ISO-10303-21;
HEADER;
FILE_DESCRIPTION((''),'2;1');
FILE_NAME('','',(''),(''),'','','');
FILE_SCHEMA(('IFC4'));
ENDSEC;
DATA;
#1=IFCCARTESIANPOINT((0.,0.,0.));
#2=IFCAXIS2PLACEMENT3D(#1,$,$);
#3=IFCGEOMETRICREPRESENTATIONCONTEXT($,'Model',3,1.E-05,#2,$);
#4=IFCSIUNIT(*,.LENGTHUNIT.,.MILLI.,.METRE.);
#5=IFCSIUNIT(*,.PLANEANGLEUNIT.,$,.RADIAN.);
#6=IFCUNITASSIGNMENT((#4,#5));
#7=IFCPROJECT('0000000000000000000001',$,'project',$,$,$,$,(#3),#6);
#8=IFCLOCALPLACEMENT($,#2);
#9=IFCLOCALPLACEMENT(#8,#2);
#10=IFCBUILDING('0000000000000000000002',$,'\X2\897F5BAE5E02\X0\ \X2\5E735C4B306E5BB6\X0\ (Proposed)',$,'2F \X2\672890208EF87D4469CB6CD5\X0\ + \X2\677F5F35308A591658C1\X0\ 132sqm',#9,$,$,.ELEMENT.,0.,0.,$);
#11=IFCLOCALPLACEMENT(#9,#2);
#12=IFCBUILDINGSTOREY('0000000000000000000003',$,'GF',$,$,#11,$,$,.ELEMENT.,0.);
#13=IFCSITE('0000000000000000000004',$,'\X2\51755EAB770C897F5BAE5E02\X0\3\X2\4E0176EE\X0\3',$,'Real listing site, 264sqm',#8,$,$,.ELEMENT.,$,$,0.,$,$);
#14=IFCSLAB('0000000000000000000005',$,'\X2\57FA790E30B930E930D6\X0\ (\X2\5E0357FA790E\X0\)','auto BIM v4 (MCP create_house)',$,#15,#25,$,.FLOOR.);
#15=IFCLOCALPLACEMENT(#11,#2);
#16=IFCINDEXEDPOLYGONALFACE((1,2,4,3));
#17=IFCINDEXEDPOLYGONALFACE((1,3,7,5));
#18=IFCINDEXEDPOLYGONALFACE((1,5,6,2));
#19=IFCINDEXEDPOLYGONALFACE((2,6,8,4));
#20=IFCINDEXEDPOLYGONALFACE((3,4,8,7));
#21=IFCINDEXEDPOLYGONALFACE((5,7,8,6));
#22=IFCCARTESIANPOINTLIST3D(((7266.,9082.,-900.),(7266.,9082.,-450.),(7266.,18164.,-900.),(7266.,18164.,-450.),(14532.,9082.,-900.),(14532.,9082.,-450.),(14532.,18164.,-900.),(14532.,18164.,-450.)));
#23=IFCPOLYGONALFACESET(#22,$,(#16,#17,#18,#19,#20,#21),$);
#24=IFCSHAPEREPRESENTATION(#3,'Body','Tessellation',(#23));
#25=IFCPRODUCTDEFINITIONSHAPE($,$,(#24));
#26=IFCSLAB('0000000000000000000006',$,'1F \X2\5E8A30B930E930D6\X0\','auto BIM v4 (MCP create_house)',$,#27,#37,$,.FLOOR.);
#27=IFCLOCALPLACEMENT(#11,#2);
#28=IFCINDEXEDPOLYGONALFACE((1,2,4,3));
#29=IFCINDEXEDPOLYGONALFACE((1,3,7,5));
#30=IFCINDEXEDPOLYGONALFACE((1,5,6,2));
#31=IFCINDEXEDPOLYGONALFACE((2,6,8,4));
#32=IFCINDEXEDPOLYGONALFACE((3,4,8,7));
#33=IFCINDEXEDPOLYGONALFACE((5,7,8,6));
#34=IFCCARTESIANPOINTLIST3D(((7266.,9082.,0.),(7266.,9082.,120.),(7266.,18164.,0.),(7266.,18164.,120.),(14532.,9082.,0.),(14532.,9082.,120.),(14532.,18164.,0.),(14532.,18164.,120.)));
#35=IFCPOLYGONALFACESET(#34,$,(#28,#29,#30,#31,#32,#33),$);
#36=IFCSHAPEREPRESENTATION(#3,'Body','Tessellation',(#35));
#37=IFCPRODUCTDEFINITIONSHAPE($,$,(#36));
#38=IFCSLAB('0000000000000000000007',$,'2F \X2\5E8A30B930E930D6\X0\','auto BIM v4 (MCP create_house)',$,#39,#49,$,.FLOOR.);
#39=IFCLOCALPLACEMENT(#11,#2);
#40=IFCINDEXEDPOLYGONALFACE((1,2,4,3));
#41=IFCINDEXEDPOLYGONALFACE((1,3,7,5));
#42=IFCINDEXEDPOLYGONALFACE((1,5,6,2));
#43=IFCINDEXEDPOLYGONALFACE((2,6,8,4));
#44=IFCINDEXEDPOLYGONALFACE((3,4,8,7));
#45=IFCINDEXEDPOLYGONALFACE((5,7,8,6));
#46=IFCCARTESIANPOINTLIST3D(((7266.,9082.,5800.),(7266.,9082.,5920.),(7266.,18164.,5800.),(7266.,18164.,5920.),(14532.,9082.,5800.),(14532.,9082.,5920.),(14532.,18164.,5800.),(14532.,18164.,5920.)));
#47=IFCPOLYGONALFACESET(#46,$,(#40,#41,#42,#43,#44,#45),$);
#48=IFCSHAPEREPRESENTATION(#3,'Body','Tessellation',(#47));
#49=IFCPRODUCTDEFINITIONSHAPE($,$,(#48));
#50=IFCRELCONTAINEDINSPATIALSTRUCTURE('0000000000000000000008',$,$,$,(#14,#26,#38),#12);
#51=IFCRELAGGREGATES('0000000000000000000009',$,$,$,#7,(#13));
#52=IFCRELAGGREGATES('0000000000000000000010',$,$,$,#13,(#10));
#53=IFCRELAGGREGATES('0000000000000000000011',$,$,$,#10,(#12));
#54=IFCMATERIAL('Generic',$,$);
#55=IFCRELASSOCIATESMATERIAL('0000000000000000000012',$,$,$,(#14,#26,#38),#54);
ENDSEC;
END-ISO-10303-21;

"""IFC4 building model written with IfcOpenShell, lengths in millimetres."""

from ifc_helpers import new_model, si_unit, frame, frame_2d, origin, place, context, project, spatial, rectangle, extrude, material, element, save


model = new_model("IFC4")

# Units and contexts
model_context = context("Model", 3, precision=1e-05, world=origin())
ifc_project = project(units=[si_unit("LENGTHUNIT", "METRE", prefix="MILLI"), si_unit("PLANEANGLEUNIT", "RADIAN")], contexts=[model_context])

# Site, building, storey
site_placement = place(None, origin())
site = spatial("IfcSite", under=ifc_project, at=site_placement, Name="兵庫県西宮市3丁目3", ObjectType="Real listing site, 264sqm", CompositionType="ELEMENT", RefElevation=0.0)
building_placement = place(site_placement, origin())
building = spatial("IfcBuilding", under=site, at=building_placement, Name="西宮市 平屋の家 (Proposed)", ObjectType="2F 木造軸組構法 + 板張り外壁 132sqm", CompositionType="ELEMENT", ElevationOfRefHeight=0.0, ElevationOfTerrain=0.0)
storey_placement = place(building_placement, origin())
storey = spatial("IfcBuildingStorey", under=building, at=storey_placement, Name="GF", CompositionType="ELEMENT", Elevation=0.0)

# Slabs
ifc_material = material(Name="Generic")
slab_1_placement = place(storey_placement, frame((3633.0, 4541.0, -450.0)))
element("IfcSlab", 1, at=slab_1_placement, inside=storey, material=ifc_material, Name="基礎スラブ (布基礎)", Description="auto BIM v4 (MCP create_house)", PredefinedType="FLOOR", context=model_context, shape_type="SweptSolid", body=[
    extrude(rectangle(XDim=7266.0, YDim=9082.0, at=frame_2d((3633.0, 4541.0))), frame((3633.0, 4541.0, -450.0)), (0.0, 0.0, 1.0), 450.0),
])
slab_2_placement = place(storey_placement, frame((3633.0, 4541.0, 0.0)))
element("IfcSlab", 2, at=slab_2_placement, inside=storey, material=ifc_material, Name="1F 床スラブ", Description="auto BIM v4 (MCP create_house)", PredefinedType="FLOOR", context=model_context, shape_type="SweptSolid", body=[
    extrude(rectangle(XDim=7266.0, YDim=9082.0, at=frame_2d((3633.0, 4541.0))), frame((3633.0, 4541.0, 0.0)), (0.0, 0.0, 1.0), 120.0),
])
slab_3_placement = place(storey_placement, frame((3633.0, 4541.0, 2900.0)))
element("IfcSlab", 3, at=slab_3_placement, inside=storey, material=ifc_material, Name="2F 床スラブ", Description="auto BIM v4 (MCP create_house)", PredefinedType="FLOOR", context=model_context, shape_type="SweptSolid", body=[
    extrude(rectangle(XDim=7266.0, YDim=9082.0, at=frame_2d((3633.0, 4541.0))), frame((3633.0, 4541.0, 2900.0)), (0.0, 0.0, 1.0), 120.0),
])

save(model, "model.ifc")
